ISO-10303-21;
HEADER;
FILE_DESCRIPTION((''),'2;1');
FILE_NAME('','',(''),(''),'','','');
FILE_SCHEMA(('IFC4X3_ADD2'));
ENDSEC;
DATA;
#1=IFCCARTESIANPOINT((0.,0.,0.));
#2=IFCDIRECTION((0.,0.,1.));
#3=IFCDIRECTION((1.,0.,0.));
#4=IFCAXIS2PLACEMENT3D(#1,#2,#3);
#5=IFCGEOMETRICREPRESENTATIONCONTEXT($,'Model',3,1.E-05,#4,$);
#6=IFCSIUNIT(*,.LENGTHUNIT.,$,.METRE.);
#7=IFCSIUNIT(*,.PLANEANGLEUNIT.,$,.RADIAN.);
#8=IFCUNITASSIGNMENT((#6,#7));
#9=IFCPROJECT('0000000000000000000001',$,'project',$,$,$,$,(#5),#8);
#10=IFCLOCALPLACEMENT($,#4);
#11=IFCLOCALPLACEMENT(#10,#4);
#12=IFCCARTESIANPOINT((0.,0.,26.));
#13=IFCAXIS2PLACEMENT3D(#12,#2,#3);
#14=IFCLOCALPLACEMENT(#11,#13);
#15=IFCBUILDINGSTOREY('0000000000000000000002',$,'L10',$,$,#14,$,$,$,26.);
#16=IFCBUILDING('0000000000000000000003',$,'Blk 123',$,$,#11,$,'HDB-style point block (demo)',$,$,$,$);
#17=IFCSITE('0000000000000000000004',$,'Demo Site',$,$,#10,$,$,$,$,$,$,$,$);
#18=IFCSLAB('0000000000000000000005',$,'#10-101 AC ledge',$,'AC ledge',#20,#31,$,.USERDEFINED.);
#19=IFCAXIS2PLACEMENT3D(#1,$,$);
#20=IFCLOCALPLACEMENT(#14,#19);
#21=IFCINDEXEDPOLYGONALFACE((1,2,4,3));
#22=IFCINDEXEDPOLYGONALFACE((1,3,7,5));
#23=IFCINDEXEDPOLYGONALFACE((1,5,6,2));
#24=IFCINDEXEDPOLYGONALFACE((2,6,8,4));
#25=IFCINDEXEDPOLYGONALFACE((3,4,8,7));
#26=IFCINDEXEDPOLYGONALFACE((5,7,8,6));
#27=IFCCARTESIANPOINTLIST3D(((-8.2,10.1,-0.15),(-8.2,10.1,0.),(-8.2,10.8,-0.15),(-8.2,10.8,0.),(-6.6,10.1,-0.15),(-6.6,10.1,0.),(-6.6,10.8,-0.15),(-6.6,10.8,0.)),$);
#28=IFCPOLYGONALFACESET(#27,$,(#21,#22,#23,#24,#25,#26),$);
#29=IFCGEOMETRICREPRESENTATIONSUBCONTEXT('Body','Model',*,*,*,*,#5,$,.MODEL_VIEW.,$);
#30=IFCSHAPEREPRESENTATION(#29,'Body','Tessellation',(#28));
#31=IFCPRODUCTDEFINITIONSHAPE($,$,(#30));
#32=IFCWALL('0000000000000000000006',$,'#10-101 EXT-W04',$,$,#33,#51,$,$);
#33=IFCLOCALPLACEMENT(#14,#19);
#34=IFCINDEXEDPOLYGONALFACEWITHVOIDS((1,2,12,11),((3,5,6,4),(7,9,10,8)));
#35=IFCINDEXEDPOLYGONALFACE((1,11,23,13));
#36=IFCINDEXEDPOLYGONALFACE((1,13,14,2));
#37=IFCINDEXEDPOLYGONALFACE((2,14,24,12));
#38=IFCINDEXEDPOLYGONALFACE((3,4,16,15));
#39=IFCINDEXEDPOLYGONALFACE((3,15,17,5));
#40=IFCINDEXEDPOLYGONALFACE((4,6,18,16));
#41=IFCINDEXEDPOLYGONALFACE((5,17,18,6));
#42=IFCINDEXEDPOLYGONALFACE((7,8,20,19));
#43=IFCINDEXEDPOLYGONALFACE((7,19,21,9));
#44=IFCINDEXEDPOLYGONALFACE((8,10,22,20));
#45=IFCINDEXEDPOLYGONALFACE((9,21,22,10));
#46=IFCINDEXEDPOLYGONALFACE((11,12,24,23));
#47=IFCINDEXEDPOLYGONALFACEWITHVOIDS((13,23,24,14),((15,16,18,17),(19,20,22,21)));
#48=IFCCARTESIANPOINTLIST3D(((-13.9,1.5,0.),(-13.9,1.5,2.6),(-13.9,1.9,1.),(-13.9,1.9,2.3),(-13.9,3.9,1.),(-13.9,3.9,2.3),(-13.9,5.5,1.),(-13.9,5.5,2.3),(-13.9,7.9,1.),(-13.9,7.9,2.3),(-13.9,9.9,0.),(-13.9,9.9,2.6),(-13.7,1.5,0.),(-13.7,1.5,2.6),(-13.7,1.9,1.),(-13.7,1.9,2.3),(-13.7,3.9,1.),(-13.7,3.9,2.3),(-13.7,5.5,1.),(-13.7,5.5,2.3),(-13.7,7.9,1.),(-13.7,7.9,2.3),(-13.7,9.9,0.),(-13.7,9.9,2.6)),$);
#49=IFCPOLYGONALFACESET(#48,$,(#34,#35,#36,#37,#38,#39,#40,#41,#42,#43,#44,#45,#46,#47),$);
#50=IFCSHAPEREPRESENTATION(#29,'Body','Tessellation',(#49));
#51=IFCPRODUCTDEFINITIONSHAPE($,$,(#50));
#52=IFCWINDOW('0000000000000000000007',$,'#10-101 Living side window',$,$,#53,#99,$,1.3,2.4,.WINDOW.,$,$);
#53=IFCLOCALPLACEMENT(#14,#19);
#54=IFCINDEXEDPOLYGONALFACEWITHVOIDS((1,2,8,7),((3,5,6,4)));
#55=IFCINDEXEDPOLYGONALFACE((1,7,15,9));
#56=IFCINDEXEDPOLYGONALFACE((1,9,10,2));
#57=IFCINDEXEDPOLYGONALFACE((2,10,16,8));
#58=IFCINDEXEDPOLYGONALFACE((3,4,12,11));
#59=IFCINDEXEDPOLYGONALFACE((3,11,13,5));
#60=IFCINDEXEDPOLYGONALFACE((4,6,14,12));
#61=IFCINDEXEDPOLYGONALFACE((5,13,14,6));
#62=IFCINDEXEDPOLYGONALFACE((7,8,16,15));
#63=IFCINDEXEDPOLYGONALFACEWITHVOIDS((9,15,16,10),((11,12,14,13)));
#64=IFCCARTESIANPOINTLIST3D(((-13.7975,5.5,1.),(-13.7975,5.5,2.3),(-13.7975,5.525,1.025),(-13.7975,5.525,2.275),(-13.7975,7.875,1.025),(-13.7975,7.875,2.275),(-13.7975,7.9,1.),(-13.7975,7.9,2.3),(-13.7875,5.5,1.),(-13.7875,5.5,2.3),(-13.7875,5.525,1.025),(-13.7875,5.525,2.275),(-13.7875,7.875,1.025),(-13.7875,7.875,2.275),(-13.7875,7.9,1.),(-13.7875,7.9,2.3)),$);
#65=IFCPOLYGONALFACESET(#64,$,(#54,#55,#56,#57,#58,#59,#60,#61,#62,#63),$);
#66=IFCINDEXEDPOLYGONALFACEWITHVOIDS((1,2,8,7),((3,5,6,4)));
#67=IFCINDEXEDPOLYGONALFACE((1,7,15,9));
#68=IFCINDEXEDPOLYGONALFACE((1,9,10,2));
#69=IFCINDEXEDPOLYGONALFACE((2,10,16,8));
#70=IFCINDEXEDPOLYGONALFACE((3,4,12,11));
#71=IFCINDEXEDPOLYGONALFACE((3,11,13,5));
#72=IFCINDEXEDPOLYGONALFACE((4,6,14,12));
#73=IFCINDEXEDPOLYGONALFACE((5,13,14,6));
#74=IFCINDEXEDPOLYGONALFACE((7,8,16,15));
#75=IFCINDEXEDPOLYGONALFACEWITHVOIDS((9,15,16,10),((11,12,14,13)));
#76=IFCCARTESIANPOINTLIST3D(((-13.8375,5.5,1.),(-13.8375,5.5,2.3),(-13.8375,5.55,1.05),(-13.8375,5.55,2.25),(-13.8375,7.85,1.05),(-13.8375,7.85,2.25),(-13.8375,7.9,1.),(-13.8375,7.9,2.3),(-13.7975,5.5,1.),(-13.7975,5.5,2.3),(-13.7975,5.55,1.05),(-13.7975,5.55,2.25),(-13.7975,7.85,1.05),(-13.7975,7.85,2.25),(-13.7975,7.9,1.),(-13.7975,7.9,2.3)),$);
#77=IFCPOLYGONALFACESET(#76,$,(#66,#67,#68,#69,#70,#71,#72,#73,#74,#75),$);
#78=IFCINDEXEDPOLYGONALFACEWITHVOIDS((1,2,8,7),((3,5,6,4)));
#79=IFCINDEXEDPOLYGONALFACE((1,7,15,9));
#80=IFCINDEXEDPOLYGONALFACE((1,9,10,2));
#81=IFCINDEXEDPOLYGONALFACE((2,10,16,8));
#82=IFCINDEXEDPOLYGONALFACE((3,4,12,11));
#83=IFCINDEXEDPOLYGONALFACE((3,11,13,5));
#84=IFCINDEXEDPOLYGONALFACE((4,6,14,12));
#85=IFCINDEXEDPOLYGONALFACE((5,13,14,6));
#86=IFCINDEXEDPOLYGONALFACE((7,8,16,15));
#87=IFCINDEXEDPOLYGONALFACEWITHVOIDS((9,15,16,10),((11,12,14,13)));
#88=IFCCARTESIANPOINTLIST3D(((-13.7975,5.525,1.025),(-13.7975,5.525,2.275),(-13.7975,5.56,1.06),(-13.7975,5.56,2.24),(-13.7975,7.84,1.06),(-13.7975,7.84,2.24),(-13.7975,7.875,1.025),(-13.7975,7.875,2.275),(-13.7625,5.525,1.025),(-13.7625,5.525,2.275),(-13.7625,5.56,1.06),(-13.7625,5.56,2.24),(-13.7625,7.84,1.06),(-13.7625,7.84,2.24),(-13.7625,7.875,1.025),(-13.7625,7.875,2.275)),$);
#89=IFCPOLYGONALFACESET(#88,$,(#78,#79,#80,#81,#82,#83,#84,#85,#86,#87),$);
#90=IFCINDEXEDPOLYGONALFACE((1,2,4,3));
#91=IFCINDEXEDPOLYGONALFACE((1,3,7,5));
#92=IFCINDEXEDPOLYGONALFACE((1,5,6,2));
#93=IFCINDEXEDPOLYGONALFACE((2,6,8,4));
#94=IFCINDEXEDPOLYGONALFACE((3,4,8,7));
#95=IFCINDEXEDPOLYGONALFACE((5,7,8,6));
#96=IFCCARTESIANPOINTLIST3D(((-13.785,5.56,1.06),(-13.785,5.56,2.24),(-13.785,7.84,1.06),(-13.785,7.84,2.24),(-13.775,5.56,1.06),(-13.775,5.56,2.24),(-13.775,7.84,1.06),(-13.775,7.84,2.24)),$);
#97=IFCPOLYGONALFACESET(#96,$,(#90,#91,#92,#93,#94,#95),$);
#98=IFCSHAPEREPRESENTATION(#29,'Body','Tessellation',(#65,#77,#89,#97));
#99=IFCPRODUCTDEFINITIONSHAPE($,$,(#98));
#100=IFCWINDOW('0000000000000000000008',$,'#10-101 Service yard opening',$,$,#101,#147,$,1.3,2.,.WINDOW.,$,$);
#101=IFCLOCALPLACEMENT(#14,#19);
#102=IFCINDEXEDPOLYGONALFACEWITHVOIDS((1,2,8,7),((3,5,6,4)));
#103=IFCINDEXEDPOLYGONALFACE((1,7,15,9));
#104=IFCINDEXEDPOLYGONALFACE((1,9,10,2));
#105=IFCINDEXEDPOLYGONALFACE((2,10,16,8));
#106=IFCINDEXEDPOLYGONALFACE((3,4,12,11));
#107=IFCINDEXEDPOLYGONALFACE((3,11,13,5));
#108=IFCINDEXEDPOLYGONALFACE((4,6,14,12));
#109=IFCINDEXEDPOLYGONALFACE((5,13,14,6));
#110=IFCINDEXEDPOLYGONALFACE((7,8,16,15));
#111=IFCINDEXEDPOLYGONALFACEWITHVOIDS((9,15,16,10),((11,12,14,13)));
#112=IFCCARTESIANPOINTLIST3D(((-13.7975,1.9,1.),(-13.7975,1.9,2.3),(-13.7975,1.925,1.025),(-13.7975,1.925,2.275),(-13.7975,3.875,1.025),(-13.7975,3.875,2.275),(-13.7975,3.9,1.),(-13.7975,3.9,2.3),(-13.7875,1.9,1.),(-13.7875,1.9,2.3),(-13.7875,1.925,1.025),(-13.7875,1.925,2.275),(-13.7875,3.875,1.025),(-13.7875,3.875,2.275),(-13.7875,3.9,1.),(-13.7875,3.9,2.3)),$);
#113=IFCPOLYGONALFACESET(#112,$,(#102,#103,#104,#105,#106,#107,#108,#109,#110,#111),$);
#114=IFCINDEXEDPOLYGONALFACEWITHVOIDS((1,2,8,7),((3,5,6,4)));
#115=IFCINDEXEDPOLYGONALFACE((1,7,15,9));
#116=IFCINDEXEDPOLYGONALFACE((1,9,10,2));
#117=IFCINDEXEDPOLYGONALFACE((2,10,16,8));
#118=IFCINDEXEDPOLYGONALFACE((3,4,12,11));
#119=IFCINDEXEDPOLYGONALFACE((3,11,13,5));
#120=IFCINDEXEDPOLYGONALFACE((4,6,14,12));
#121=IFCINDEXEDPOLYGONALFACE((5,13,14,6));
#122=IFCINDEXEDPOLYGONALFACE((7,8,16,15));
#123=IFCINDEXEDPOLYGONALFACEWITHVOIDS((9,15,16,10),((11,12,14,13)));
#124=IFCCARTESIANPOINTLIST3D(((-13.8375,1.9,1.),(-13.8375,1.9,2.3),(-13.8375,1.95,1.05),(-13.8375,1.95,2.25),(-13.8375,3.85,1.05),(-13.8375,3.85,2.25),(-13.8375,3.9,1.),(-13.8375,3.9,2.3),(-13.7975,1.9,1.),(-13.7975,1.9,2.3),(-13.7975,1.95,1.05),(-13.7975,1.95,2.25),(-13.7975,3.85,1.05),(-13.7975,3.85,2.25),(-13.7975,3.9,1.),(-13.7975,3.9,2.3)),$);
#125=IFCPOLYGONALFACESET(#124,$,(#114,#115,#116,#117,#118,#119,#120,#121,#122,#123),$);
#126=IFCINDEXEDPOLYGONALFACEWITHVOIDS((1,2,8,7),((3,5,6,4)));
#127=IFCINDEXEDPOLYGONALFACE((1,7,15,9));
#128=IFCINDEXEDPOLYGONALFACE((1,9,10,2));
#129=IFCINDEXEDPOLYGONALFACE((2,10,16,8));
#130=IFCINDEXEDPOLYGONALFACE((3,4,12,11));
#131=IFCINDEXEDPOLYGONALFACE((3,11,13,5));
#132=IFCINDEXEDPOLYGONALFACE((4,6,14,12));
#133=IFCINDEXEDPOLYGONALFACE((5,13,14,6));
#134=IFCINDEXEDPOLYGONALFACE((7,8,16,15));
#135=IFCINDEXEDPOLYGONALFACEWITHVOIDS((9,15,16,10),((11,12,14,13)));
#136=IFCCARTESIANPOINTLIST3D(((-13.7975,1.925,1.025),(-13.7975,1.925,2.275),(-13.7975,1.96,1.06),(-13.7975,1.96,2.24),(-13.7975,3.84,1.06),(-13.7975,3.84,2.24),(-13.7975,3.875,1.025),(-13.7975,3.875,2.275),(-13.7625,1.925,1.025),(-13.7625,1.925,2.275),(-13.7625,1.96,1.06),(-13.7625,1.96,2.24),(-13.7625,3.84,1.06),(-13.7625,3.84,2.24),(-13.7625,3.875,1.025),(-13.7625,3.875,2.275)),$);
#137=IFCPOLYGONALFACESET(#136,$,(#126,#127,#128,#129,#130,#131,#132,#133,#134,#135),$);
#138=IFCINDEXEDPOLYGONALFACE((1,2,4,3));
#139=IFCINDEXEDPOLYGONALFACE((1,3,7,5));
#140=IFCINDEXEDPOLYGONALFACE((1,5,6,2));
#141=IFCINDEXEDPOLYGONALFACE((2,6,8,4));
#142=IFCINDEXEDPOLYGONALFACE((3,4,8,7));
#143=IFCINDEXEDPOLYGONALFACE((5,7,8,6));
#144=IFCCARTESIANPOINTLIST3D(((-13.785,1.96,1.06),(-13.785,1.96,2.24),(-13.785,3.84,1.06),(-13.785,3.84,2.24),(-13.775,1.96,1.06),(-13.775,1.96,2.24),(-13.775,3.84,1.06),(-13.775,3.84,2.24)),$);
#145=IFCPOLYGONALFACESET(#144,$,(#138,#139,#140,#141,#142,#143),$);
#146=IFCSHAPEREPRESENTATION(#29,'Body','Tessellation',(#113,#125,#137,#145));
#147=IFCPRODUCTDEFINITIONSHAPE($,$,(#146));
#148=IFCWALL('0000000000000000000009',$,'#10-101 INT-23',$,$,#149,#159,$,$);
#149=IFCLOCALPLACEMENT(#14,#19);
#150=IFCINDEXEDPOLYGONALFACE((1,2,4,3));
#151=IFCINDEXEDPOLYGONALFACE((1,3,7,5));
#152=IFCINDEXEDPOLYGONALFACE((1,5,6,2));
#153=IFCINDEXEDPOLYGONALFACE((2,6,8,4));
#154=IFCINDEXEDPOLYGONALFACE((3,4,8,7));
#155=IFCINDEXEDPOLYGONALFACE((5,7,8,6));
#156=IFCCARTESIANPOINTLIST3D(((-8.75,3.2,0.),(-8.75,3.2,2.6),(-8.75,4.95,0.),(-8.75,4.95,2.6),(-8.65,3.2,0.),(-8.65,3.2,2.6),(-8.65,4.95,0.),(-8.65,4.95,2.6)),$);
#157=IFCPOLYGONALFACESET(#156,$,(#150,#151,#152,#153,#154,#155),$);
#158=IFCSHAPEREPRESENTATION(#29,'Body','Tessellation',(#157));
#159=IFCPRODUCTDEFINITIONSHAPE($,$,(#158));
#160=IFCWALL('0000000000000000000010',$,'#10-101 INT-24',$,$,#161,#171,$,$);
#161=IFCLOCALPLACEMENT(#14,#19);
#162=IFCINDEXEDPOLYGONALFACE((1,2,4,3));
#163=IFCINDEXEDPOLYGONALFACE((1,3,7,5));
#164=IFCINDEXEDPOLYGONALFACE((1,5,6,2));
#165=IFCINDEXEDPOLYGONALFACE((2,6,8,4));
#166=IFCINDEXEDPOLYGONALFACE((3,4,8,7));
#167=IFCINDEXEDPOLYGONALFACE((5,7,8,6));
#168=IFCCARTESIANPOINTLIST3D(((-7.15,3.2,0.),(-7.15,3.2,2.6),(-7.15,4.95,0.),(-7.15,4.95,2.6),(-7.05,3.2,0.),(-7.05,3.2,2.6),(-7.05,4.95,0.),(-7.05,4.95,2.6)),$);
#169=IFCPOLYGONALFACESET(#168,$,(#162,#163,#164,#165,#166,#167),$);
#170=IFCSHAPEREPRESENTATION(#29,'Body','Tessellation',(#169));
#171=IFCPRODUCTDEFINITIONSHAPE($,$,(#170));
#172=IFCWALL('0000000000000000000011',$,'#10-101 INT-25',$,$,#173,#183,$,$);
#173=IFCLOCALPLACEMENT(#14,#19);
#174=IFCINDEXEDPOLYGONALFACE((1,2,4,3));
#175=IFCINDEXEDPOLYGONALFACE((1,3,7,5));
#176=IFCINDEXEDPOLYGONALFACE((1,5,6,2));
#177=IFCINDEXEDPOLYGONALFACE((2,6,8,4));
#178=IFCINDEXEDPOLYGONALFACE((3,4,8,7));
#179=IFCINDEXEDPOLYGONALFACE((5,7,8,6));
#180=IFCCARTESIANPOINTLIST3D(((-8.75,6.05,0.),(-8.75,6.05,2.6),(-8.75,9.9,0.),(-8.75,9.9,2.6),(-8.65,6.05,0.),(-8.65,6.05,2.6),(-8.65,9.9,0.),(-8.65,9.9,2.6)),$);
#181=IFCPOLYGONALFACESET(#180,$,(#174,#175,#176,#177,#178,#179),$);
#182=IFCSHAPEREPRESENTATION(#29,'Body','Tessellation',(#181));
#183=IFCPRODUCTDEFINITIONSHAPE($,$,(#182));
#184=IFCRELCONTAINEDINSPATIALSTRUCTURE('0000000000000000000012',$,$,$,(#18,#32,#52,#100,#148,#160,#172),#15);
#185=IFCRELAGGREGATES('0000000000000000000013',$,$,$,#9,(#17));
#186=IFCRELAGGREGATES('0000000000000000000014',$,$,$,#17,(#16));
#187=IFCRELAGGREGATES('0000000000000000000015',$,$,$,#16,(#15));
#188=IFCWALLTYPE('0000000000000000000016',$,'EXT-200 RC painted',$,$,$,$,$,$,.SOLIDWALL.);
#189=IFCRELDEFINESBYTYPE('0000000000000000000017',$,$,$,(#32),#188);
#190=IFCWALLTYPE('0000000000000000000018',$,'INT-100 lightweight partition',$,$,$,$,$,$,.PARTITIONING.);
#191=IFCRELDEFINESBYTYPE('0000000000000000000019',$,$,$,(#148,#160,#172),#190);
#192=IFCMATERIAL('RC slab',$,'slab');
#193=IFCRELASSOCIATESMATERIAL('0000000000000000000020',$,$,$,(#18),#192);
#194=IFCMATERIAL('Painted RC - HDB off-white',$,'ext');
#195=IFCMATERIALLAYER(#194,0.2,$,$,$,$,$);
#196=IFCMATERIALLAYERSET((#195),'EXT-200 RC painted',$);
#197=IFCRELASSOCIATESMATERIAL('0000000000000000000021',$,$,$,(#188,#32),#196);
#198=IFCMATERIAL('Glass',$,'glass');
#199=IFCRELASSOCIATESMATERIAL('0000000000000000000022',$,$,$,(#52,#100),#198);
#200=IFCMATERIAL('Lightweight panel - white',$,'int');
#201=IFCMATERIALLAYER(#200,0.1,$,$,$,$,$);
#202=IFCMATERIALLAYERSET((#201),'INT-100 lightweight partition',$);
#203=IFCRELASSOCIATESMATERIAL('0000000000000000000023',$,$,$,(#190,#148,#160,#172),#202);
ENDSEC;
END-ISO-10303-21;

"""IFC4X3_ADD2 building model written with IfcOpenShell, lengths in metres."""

from ifc_helpers import new_model, si_unit, frame, origin, origin_with_axes, place, context, subcontext, project, spatial, polyline, line, indexed_curve, outline, extrude, material, layer, layer_set, layer_usage, type_object, element, fill, save


model = new_model("IFC4X3_ADD2")

# Units and contexts
model_context = context("Model", 3, precision=1e-05, world=origin_with_axes())
body_context = subcontext(model_context, "Body", "Model", "MODEL_VIEW")
ifc_project = project(units=[si_unit("LENGTHUNIT", "METRE"), si_unit("PLANEANGLEUNIT", "RADIAN")], contexts=[model_context])

# Site, building, storey
site_placement = place(None, origin_with_axes())
site = spatial("IfcSite", under=ifc_project, at=site_placement, Name="Demo Site")
building_placement = place(site_placement, origin_with_axes())
building = spatial("IfcBuilding", under=site, at=building_placement, Name="Blk 123", LongName="HDB-style point block (demo)")
storey_placement = place(building_placement, frame((0.0, 0.0, 26.0), z_axis=(0.0, 0.0, 1.0), x_axis=(1.0, 0.0, 0.0)))
storey = spatial("IfcBuildingStorey", under=building, at=storey_placement, Name="L10", Elevation=26.0)

# Slab
ifc_material_1 = material(Name="RC slab", Category="slab")
slab_placement = place(storey_placement, frame((-7.4, 10.45, -0.15), z_axis=(0.0, 0.0, 1.0), x_axis=(1.0, 0.0, 0.0)))
element("IfcSlab", 1, at=slab_placement, inside=storey, material=ifc_material_1, Name="#10-101 AC ledge", ObjectType="AC ledge", PredefinedType="USERDEFINED", context=body_context, shape_type="SweptSolid", body=[
    extrude(outline(polyline([(-0.8, -0.35), (0.8, -0.35), (0.8, 0.35), (-0.8, 0.35), (-0.8, -0.35)])), origin(), (0.0, 0.0, 1.0), 0.15),
])

# Shared definitions
ifc_material_2 = material(Name="Painted RC - HDB off-white", Category="ext")
ifc_layer_1 = layer(ifc_material_2, 0.2)
ifc_layer_set_1 = layer_set([ifc_layer_1], Name="EXT-200 RC painted")
ifc_layer_usage_1 = layer_usage(ifc_layer_set_1, "AXIS2", "POSITIVE", 0.0)
wall_type_1 = type_object("IfcWallType", Name="EXT-200 RC painted", PredefinedType="SOLIDWALL", material=ifc_layer_set_1)
ifc_material_3 = material(Name="Glass", Category="glass")

# Wall, openings, windows
wall_1_placement = place(storey_placement, frame((-13.9, 9.9, 0.0), z_axis=(0.0, 0.0, 1.0), x_axis=(0.0, -1.0, 0.0)))
wall_1 = element("IfcWall", 2, at=wall_1_placement, inside=storey, type_object=wall_type_1, material=ifc_layer_usage_1, Name="#10-101 EXT-W04", context=body_context, shape_type="SweptSolid", body=[
    extrude(outline(indexed_curve([(0.0, 0.0), (0.0, 0.2), (8.4, 0.2), (8.4, 0.0), (0.0, 0.0)], self_intersect=False)), origin_with_axes(), (0.0, 0.0, 1.0), 2.6),
])
opening_1_placement = place(wall_1_placement, frame((2.0, -0.1, 1.0), z_axis=(0.0, 0.0, 1.0), x_axis=(1.0, 0.0, 0.0)))
opening_1 = element("IfcOpeningElement", 3, at=opening_1_placement, cuts=wall_1, context=body_context, shape_type="SweptSolid", body=[
    extrude(outline(indexed_curve([(0.0, 0.0), (0.0, 0.4), (2.4, 0.4), (2.4, 0.0), (0.0, 0.0)], self_intersect=False)), origin_with_axes(), (0.0, 0.0, 1.0), 1.3),
])
opening_2_placement = place(wall_1_placement, frame((6.0, -0.1, 1.0), z_axis=(0.0, 0.0, 1.0), x_axis=(1.0, 0.0, 0.0)))
opening_2 = element("IfcOpeningElement", 4, at=opening_2_placement, cuts=wall_1, context=body_context, shape_type="SweptSolid", body=[
    extrude(outline(indexed_curve([(0.0, 0.0), (0.0, 0.4), (2.0, 0.4), (2.0, 0.0), (0.0, 0.0)], self_intersect=False)), origin_with_axes(), (0.0, 0.0, 1.0), 1.3),
])
window_1_placement = place(opening_1_placement, frame((0.0, 0.1125, 0.0), z_axis=(0.0, 0.0, 1.0), x_axis=(1.0, 0.0, 0.0)))
window_1 = element("IfcWindow", 5, at=window_1_placement, inside=storey, material=ifc_material_3, Name="#10-101 Living side window", OverallHeight=1.3, OverallWidth=2.4, PredefinedType="WINDOW", context=body_context, shape_type="SweptSolid", body=[
    extrude(outline(indexed_curve([(0.0, 0.0), (2.4, 0.0), (2.4, 1.3), (0.0, 1.3)], segments=[line(1, 2, 3, 4, 1)]), holes=[indexed_curve([(0.025, 0.025), (2.375, 0.025), (2.375, 1.275), (0.025, 1.275)], segments=[line(1, 2, 3, 4, 1)])]), frame((0.0, 0.09, 0.0), z_axis=(0.0, -1.0, 0.0), x_axis=(1.0, 0.0, 0.0)), (0.0, 0.0, -1.0), 0.01),
    extrude(outline(indexed_curve([(0.0, 0.0), (2.4, 0.0), (2.4, 1.3), (0.0, 1.3)], segments=[line(1, 2, 3, 4, 1)]), holes=[indexed_curve([(0.05, 0.05), (2.35, 0.05), (2.35, 1.25), (0.05, 1.25)], segments=[line(1, 2, 3, 4, 1)])]), frame((0.0, 0.05, 0.0), z_axis=(0.0, -1.0, 0.0), x_axis=(1.0, 0.0, 0.0)), (0.0, 0.0, -1.0), 0.04),
    extrude(outline(indexed_curve([(0.0, 0.0), (2.35, 0.0), (2.35, 1.25), (0.0, 1.25)], segments=[line(1, 2, 3, 4, 1)]), holes=[indexed_curve([(0.035, 0.035), (2.315, 0.035), (2.315, 1.215), (0.035, 1.215)], segments=[line(1, 2, 3, 4, 1)])]), frame((0.025, 0.09, 0.025), z_axis=(0.0, -1.0, 0.0), x_axis=(1.0, 0.0, 0.0)), (0.0, 0.0, -1.0), 0.035),
    extrude(outline(indexed_curve([(0.035, 0.035), (2.315, 0.035), (2.315, 1.215), (0.035, 1.215)], segments=[line(1, 2, 3, 4, 1)])), frame((0.025, 0.1025, 0.025), z_axis=(0.0, -1.0, 0.0), x_axis=(1.0, 0.0, 0.0)), (0.0, 0.0, -1.0), 0.01),
])
fill(opening_1, window_1)
window_2_placement = place(opening_2_placement, frame((0.0, 0.1125, 0.0), z_axis=(0.0, 0.0, 1.0), x_axis=(1.0, 0.0, 0.0)))
window_2 = element("IfcWindow", 6, at=window_2_placement, inside=storey, material=ifc_material_3, Name="#10-101 Service yard opening", OverallHeight=1.3, OverallWidth=2.0, PredefinedType="WINDOW", context=body_context, shape_type="SweptSolid", body=[
    extrude(outline(indexed_curve([(0.0, 0.0), (2.0, 0.0), (2.0, 1.3), (0.0, 1.3)], segments=[line(1, 2, 3, 4, 1)]), holes=[indexed_curve([(0.025, 0.025), (1.975, 0.025), (1.975, 1.275), (0.025, 1.275)], segments=[line(1, 2, 3, 4, 1)])]), frame((0.0, 0.09, 0.0), z_axis=(0.0, -1.0, 0.0), x_axis=(1.0, 0.0, 0.0)), (0.0, 0.0, -1.0), 0.01),
    extrude(outline(indexed_curve([(0.0, 0.0), (2.0, 0.0), (2.0, 1.3), (0.0, 1.3)], segments=[line(1, 2, 3, 4, 1)]), holes=[indexed_curve([(0.05, 0.05), (1.95, 0.05), (1.95, 1.25), (0.05, 1.25)], segments=[line(1, 2, 3, 4, 1)])]), frame((0.0, 0.05, 0.0), z_axis=(0.0, -1.0, 0.0), x_axis=(1.0, 0.0, 0.0)), (0.0, 0.0, -1.0), 0.04),
    extrude(outline(indexed_curve([(0.0, 0.0), (1.95, 0.0), (1.95, 1.25), (0.0, 1.25)], segments=[line(1, 2, 3, 4, 1)]), holes=[indexed_curve([(0.035, 0.035), (1.915, 0.035), (1.915, 1.215), (0.035, 1.215)], segments=[line(1, 2, 3, 4, 1)])]), frame((0.025, 0.09, 0.025), z_axis=(0.0, -1.0, 0.0), x_axis=(1.0, 0.0, 0.0)), (0.0, 0.0, -1.0), 0.035),
    extrude(outline(indexed_curve([(0.035, 0.035), (1.915, 0.035), (1.915, 1.215), (0.035, 1.215)], segments=[line(1, 2, 3, 4, 1)])), frame((0.025, 0.1025, 0.025), z_axis=(0.0, -1.0, 0.0), x_axis=(1.0, 0.0, 0.0)), (0.0, 0.0, -1.0), 0.01),
])
fill(opening_2, window_2)

# Walls
ifc_material_4 = material(Name="Lightweight panel - white", Category="int")
ifc_layer_2 = layer(ifc_material_4, 0.1)
ifc_layer_set_2 = layer_set([ifc_layer_2], Name="INT-100 lightweight partition")
ifc_layer_usage_2 = layer_usage(ifc_layer_set_2, "AXIS2", "POSITIVE", -0.05)
wall_type_2 = type_object("IfcWallType", Name="INT-100 lightweight partition", PredefinedType="PARTITIONING", material=ifc_layer_set_2)
for number, where, z_axis, x_axis, name in (
    (7, (-8.7, 3.2, 0.0), (0.0, 0.0, 1.0), (0.0, 1.0, 0.0), "#10-101 INT-23"),
    (8, (-7.1, 3.2, 0.0), (0.0, 0.0, 1.0), (0.0, 1.0, 0.0), "#10-101 INT-24"),
):
    element("IfcWall", number, at=place(storey_placement, frame(where, z_axis=z_axis, x_axis=x_axis)), inside=storey, type_object=wall_type_2, material=ifc_layer_usage_2, Name=name, context=body_context, shape_type="SweptSolid", body=[
        extrude(outline(indexed_curve([(0.0, 0.0), (0.0, 0.1), (1.75, 0.1), (1.75, 0.0), (0.0, 0.0)], self_intersect=False)), frame((0.0, -0.05, 0.0), z_axis=(0.0, 0.0, 1.0), x_axis=(1.0, 0.0, 0.0)), (0.0, 0.0, 1.0), 2.6),
    ])
wall_2_placement = place(storey_placement, frame((-8.7, 6.05, 0.0), z_axis=(0.0, 0.0, 1.0), x_axis=(0.0, 1.0, 0.0)))
element("IfcWall", 9, at=wall_2_placement, inside=storey, type_object=wall_type_2, material=ifc_layer_usage_2, Name="#10-101 INT-25", context=body_context, shape_type="SweptSolid", body=[
    extrude(outline(indexed_curve([(0.0, 0.0), (0.0, 0.1), (3.85, 0.1), (3.85, 0.0), (0.0, 0.0)], self_intersect=False)), frame((0.0, -0.05, 0.0), z_axis=(0.0, 0.0, 1.0), x_axis=(1.0, 0.0, 0.0)), (0.0, 0.0, 1.0), 2.6),
])

save(model, "model.ifc")
